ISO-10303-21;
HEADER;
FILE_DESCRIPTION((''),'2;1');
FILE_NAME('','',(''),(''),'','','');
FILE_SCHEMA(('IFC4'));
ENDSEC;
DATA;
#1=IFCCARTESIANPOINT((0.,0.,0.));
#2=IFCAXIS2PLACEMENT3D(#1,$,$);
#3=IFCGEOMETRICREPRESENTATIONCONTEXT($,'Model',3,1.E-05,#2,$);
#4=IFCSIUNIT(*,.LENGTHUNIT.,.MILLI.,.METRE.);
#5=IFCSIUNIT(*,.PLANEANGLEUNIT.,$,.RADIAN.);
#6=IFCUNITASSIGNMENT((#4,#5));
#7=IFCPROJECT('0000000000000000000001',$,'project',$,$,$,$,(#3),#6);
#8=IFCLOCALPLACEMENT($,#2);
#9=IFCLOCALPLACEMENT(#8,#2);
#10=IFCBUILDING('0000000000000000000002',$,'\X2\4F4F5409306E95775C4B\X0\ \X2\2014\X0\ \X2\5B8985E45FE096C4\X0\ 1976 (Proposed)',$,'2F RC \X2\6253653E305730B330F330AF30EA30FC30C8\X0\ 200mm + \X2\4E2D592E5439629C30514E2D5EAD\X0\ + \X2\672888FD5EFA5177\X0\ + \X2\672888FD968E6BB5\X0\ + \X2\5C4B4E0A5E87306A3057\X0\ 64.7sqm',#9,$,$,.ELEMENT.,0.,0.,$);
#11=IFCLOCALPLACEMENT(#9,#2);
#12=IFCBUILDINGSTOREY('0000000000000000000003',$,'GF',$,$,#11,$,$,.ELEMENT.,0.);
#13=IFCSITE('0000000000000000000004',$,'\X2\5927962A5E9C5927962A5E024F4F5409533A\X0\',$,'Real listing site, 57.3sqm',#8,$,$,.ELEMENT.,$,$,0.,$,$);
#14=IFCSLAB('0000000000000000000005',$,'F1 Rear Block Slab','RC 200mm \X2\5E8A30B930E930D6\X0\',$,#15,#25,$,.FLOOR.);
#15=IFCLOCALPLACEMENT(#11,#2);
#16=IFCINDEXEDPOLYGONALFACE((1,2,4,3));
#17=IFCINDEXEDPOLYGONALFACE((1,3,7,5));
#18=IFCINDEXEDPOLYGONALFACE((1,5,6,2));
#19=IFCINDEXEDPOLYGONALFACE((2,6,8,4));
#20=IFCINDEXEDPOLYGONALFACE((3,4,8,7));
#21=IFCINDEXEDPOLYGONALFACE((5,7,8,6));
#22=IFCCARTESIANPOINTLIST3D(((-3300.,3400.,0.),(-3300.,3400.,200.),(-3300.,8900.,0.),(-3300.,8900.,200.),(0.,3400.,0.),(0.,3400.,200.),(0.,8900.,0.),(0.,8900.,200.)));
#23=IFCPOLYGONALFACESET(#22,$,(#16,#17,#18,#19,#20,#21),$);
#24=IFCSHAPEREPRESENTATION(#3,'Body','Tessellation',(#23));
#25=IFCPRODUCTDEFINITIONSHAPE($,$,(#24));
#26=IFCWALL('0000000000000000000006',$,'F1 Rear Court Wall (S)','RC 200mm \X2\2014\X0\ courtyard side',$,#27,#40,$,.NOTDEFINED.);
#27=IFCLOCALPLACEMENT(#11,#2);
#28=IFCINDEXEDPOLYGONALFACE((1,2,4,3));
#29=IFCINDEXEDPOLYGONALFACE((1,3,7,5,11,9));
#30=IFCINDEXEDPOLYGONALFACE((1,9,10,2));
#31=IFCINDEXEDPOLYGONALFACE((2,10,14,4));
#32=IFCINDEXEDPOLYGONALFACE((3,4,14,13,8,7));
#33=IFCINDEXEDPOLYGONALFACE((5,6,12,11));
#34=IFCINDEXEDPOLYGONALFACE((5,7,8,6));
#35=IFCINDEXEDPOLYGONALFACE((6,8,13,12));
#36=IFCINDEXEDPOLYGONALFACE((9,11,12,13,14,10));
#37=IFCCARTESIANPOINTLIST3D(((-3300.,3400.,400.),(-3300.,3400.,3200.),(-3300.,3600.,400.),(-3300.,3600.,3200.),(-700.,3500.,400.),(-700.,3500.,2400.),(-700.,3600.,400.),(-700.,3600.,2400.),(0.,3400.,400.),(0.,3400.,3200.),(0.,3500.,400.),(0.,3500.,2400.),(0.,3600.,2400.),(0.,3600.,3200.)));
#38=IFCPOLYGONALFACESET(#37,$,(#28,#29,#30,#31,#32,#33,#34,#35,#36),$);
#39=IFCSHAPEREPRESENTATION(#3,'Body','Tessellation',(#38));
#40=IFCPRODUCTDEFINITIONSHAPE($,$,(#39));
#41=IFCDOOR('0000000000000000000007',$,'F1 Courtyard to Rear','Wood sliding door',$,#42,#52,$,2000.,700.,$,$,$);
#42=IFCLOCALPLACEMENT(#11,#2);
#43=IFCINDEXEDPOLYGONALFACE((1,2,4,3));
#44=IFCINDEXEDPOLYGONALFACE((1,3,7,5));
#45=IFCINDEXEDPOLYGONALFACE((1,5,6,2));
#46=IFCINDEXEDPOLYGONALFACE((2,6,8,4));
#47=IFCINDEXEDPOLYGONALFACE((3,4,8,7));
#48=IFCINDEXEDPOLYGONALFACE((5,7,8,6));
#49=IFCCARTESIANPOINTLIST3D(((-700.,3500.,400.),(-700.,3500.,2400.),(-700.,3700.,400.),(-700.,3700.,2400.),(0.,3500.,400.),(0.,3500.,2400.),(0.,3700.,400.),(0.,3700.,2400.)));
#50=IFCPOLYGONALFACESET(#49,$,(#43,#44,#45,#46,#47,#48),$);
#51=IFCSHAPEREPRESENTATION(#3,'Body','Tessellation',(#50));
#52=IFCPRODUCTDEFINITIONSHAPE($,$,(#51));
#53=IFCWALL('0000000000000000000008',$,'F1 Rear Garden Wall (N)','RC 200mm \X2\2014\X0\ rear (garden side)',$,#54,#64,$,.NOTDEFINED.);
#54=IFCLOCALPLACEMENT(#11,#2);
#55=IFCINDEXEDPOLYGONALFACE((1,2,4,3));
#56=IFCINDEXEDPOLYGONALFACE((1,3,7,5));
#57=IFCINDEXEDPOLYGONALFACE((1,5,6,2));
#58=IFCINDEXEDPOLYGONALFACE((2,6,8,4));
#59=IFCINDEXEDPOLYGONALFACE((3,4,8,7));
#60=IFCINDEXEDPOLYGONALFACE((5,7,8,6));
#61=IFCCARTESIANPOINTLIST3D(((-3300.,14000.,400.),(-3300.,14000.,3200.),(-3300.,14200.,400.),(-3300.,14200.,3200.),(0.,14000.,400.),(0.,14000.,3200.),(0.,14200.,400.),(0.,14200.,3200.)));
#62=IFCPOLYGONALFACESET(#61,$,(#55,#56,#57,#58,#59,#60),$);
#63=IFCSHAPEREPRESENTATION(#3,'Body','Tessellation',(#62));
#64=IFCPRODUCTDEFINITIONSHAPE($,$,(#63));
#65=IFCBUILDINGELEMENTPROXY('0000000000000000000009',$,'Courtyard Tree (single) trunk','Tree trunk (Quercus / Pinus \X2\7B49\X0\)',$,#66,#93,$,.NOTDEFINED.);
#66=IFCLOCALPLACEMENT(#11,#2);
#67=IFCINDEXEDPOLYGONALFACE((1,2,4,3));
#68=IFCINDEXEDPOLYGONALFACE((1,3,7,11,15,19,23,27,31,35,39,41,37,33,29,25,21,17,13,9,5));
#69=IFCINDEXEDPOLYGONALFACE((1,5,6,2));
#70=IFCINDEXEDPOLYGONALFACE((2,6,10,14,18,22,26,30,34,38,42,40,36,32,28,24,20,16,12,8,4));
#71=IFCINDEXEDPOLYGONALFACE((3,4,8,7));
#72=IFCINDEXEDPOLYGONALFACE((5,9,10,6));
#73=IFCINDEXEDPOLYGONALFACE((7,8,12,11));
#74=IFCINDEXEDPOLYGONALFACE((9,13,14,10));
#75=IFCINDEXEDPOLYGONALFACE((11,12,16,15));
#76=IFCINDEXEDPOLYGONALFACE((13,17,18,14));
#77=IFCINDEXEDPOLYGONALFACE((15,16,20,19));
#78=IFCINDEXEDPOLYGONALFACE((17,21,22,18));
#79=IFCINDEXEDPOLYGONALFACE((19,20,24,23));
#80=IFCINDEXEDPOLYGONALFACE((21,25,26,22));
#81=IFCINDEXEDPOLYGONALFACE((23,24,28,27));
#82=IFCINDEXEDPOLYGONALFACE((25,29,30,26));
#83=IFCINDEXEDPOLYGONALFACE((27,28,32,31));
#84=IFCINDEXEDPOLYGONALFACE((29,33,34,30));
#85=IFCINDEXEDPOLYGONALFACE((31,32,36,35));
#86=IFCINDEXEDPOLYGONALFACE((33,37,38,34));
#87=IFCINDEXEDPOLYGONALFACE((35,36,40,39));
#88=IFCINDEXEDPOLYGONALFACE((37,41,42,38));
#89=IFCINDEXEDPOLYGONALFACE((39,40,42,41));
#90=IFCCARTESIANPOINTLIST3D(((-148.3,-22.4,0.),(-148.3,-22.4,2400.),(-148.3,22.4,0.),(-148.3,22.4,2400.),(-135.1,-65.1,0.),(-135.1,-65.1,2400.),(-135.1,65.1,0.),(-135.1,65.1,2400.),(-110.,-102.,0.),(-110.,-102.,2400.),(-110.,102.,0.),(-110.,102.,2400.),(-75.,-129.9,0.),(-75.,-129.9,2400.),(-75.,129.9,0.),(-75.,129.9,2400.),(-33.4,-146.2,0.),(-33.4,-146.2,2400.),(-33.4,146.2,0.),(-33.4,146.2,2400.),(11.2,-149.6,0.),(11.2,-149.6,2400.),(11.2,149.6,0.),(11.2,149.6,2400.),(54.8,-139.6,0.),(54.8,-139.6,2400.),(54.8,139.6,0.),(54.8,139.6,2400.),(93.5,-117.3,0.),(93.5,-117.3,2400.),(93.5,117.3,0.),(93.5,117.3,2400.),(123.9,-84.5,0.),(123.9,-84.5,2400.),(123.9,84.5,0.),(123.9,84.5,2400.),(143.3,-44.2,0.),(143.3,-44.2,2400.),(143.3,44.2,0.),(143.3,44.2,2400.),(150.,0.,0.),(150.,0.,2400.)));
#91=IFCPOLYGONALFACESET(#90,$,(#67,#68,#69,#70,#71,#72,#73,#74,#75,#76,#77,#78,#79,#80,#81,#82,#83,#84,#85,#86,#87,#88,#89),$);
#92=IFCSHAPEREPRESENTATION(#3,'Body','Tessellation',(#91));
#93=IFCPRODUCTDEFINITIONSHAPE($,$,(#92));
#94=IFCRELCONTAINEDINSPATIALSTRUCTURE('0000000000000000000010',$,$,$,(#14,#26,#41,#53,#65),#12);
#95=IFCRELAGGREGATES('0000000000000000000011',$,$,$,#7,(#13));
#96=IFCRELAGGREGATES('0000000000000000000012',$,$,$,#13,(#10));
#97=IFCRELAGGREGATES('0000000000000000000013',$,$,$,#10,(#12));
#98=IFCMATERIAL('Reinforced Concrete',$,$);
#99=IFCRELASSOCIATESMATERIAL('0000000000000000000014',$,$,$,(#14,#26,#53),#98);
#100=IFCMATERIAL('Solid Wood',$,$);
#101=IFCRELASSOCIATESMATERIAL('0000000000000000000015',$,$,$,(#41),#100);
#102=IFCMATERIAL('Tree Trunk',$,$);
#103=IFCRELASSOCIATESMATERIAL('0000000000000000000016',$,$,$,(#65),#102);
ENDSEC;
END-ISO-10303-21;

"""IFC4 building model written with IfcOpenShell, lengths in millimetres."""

from ifc_helpers import new_model, si_unit, frame, frame_2d, origin, origin_2d, place, context, project, spatial, rectangle, circle, extrude, material, element, fill, save


model = new_model("IFC4")

# Units and contexts
model_context = context("Model", 3, precision=1e-05, world=origin())
ifc_project = project(units=[si_unit("LENGTHUNIT", "METRE", prefix="MILLI"), si_unit("PLANEANGLEUNIT", "RADIAN")], contexts=[model_context])

# Site, building, storey
site_placement = place(None, origin())
site = spatial("IfcSite", under=ifc_project, at=site_placement, Name="大阪府大阪市住吉区", ObjectType="Real listing site, 57.3sqm", CompositionType="ELEMENT", RefElevation=0.0)
building_placement = place(site_placement, origin())
building = spatial("IfcBuilding", under=site, at=building_placement, Name="住吉の長屋 — 安藤忠雄 1976 (Proposed)", ObjectType="2F RC 打放しコンクリート 200mm + 中央吹抜け中庭 + 木製建具 + 木製階段 + 屋上庇なし 64.7sqm", CompositionType="ELEMENT", ElevationOfRefHeight=0.0, ElevationOfTerrain=0.0)
storey_placement = place(building_placement, origin())
storey = spatial("IfcBuildingStorey", under=building, at=storey_placement, Name="GF", CompositionType="ELEMENT", Elevation=0.0)

# Slab
ifc_material_1 = material(Name="Reinforced Concrete")
slab_1_placement = place(storey_placement, frame((-1650.0, 1700.0, 0.0)))
element("IfcSlab", 1, at=slab_1_placement, inside=storey, material=ifc_material_1, Name="F1 Rear Block Slab", Description="RC 200mm 床スラブ", PredefinedType="FLOOR", context=model_context, shape_type="SweptSolid", body=[
    extrude(rectangle(XDim=3300.0, YDim=5500.0, at=frame_2d((1650.0, 2750.0))), frame((-1650.0, 1700.0, 0.0)), (0.0, 0.0, 1.0), 200.0),
])

# Wall, opening, door
wall_1_placement = place(storey_placement, frame((-1650.0, 1700.0, 200.0)))
wall_1 = element("IfcWall", 2, at=wall_1_placement, inside=storey, material=ifc_material_1, Name="F1 Rear Court Wall (S)", Description="RC 200mm — courtyard side", PredefinedType="NOTDEFINED", context=model_context, shape_type="SweptSolid", body=[
    extrude(rectangle(XDim=3300.0, YDim=200.0, at=frame_2d((1650.0, 100.0))), frame((-1650.0, 1700.0, 200.0)), (0.0, 0.0, 1.0), 2800.0),
])
opening_1_placement = place(storey_placement, frame((-350.0, 1750.0, 200.0)))
opening_1 = element("IfcOpeningElement", 3, at=opening_1_placement, cuts=wall_1, PredefinedType="NOTDEFINED", context=model_context, shape_type="SweptSolid", body=[
    extrude(rectangle(XDim=700.0, YDim=200.0, at=frame_2d((350.0, 100.0))), frame((-350.0, 1750.0, 200.0)), (0.0, 0.0, 1.0), 2000.0),
])
ifc_material_2 = material(Name="Solid Wood")
door_1_placement = place(storey_placement, frame((-350.0, 1750.0, 200.0)))
door_1 = element("IfcDoor", 4, at=door_1_placement, inside=storey, material=ifc_material_2, Name="F1 Courtyard to Rear", Description="Wood sliding door", OverallHeight=2000.0, OverallWidth=700.0, context=model_context, shape_type="SweptSolid", body=[
    extrude(rectangle(XDim=700.0, YDim=200.0, at=frame_2d((350.0, 100.0))), frame((-350.0, 1750.0, 200.0)), (0.0, 0.0, 1.0), 2000.0),
])
fill(opening_1, door_1)

# Wall
wall_2_placement = place(storey_placement, frame((-1650.0, 7000.0, 200.0)))
element("IfcWall", 5, at=wall_2_placement, inside=storey, material=ifc_material_1, Name="F1 Rear Garden Wall (N)", Description="RC 200mm — rear (garden side)", PredefinedType="NOTDEFINED", context=model_context, shape_type="SweptSolid", body=[
    extrude(rectangle(XDim=3300.0, YDim=200.0, at=frame_2d((1650.0, 100.0))), frame((-1650.0, 7000.0, 200.0)), (0.0, 0.0, 1.0), 2800.0),
])

# Building element proxy
ifc_material_3 = material(Name="Tree Trunk")
proxy_1_placement = place(storey_placement, origin())
element("IfcBuildingElementProxy", 6, at=proxy_1_placement, inside=storey, material=ifc_material_3, Name="Courtyard Tree (single) trunk", Description="Tree trunk (Quercus / Pinus 等)", PredefinedType="NOTDEFINED", context=model_context, shape_type="SweptSolid", body=[
    extrude(circle(Radius=150.0, at=origin_2d()), origin(), (0.0, 0.0, 1.0), 2400.0),
])

save(model, "model.ifc")
